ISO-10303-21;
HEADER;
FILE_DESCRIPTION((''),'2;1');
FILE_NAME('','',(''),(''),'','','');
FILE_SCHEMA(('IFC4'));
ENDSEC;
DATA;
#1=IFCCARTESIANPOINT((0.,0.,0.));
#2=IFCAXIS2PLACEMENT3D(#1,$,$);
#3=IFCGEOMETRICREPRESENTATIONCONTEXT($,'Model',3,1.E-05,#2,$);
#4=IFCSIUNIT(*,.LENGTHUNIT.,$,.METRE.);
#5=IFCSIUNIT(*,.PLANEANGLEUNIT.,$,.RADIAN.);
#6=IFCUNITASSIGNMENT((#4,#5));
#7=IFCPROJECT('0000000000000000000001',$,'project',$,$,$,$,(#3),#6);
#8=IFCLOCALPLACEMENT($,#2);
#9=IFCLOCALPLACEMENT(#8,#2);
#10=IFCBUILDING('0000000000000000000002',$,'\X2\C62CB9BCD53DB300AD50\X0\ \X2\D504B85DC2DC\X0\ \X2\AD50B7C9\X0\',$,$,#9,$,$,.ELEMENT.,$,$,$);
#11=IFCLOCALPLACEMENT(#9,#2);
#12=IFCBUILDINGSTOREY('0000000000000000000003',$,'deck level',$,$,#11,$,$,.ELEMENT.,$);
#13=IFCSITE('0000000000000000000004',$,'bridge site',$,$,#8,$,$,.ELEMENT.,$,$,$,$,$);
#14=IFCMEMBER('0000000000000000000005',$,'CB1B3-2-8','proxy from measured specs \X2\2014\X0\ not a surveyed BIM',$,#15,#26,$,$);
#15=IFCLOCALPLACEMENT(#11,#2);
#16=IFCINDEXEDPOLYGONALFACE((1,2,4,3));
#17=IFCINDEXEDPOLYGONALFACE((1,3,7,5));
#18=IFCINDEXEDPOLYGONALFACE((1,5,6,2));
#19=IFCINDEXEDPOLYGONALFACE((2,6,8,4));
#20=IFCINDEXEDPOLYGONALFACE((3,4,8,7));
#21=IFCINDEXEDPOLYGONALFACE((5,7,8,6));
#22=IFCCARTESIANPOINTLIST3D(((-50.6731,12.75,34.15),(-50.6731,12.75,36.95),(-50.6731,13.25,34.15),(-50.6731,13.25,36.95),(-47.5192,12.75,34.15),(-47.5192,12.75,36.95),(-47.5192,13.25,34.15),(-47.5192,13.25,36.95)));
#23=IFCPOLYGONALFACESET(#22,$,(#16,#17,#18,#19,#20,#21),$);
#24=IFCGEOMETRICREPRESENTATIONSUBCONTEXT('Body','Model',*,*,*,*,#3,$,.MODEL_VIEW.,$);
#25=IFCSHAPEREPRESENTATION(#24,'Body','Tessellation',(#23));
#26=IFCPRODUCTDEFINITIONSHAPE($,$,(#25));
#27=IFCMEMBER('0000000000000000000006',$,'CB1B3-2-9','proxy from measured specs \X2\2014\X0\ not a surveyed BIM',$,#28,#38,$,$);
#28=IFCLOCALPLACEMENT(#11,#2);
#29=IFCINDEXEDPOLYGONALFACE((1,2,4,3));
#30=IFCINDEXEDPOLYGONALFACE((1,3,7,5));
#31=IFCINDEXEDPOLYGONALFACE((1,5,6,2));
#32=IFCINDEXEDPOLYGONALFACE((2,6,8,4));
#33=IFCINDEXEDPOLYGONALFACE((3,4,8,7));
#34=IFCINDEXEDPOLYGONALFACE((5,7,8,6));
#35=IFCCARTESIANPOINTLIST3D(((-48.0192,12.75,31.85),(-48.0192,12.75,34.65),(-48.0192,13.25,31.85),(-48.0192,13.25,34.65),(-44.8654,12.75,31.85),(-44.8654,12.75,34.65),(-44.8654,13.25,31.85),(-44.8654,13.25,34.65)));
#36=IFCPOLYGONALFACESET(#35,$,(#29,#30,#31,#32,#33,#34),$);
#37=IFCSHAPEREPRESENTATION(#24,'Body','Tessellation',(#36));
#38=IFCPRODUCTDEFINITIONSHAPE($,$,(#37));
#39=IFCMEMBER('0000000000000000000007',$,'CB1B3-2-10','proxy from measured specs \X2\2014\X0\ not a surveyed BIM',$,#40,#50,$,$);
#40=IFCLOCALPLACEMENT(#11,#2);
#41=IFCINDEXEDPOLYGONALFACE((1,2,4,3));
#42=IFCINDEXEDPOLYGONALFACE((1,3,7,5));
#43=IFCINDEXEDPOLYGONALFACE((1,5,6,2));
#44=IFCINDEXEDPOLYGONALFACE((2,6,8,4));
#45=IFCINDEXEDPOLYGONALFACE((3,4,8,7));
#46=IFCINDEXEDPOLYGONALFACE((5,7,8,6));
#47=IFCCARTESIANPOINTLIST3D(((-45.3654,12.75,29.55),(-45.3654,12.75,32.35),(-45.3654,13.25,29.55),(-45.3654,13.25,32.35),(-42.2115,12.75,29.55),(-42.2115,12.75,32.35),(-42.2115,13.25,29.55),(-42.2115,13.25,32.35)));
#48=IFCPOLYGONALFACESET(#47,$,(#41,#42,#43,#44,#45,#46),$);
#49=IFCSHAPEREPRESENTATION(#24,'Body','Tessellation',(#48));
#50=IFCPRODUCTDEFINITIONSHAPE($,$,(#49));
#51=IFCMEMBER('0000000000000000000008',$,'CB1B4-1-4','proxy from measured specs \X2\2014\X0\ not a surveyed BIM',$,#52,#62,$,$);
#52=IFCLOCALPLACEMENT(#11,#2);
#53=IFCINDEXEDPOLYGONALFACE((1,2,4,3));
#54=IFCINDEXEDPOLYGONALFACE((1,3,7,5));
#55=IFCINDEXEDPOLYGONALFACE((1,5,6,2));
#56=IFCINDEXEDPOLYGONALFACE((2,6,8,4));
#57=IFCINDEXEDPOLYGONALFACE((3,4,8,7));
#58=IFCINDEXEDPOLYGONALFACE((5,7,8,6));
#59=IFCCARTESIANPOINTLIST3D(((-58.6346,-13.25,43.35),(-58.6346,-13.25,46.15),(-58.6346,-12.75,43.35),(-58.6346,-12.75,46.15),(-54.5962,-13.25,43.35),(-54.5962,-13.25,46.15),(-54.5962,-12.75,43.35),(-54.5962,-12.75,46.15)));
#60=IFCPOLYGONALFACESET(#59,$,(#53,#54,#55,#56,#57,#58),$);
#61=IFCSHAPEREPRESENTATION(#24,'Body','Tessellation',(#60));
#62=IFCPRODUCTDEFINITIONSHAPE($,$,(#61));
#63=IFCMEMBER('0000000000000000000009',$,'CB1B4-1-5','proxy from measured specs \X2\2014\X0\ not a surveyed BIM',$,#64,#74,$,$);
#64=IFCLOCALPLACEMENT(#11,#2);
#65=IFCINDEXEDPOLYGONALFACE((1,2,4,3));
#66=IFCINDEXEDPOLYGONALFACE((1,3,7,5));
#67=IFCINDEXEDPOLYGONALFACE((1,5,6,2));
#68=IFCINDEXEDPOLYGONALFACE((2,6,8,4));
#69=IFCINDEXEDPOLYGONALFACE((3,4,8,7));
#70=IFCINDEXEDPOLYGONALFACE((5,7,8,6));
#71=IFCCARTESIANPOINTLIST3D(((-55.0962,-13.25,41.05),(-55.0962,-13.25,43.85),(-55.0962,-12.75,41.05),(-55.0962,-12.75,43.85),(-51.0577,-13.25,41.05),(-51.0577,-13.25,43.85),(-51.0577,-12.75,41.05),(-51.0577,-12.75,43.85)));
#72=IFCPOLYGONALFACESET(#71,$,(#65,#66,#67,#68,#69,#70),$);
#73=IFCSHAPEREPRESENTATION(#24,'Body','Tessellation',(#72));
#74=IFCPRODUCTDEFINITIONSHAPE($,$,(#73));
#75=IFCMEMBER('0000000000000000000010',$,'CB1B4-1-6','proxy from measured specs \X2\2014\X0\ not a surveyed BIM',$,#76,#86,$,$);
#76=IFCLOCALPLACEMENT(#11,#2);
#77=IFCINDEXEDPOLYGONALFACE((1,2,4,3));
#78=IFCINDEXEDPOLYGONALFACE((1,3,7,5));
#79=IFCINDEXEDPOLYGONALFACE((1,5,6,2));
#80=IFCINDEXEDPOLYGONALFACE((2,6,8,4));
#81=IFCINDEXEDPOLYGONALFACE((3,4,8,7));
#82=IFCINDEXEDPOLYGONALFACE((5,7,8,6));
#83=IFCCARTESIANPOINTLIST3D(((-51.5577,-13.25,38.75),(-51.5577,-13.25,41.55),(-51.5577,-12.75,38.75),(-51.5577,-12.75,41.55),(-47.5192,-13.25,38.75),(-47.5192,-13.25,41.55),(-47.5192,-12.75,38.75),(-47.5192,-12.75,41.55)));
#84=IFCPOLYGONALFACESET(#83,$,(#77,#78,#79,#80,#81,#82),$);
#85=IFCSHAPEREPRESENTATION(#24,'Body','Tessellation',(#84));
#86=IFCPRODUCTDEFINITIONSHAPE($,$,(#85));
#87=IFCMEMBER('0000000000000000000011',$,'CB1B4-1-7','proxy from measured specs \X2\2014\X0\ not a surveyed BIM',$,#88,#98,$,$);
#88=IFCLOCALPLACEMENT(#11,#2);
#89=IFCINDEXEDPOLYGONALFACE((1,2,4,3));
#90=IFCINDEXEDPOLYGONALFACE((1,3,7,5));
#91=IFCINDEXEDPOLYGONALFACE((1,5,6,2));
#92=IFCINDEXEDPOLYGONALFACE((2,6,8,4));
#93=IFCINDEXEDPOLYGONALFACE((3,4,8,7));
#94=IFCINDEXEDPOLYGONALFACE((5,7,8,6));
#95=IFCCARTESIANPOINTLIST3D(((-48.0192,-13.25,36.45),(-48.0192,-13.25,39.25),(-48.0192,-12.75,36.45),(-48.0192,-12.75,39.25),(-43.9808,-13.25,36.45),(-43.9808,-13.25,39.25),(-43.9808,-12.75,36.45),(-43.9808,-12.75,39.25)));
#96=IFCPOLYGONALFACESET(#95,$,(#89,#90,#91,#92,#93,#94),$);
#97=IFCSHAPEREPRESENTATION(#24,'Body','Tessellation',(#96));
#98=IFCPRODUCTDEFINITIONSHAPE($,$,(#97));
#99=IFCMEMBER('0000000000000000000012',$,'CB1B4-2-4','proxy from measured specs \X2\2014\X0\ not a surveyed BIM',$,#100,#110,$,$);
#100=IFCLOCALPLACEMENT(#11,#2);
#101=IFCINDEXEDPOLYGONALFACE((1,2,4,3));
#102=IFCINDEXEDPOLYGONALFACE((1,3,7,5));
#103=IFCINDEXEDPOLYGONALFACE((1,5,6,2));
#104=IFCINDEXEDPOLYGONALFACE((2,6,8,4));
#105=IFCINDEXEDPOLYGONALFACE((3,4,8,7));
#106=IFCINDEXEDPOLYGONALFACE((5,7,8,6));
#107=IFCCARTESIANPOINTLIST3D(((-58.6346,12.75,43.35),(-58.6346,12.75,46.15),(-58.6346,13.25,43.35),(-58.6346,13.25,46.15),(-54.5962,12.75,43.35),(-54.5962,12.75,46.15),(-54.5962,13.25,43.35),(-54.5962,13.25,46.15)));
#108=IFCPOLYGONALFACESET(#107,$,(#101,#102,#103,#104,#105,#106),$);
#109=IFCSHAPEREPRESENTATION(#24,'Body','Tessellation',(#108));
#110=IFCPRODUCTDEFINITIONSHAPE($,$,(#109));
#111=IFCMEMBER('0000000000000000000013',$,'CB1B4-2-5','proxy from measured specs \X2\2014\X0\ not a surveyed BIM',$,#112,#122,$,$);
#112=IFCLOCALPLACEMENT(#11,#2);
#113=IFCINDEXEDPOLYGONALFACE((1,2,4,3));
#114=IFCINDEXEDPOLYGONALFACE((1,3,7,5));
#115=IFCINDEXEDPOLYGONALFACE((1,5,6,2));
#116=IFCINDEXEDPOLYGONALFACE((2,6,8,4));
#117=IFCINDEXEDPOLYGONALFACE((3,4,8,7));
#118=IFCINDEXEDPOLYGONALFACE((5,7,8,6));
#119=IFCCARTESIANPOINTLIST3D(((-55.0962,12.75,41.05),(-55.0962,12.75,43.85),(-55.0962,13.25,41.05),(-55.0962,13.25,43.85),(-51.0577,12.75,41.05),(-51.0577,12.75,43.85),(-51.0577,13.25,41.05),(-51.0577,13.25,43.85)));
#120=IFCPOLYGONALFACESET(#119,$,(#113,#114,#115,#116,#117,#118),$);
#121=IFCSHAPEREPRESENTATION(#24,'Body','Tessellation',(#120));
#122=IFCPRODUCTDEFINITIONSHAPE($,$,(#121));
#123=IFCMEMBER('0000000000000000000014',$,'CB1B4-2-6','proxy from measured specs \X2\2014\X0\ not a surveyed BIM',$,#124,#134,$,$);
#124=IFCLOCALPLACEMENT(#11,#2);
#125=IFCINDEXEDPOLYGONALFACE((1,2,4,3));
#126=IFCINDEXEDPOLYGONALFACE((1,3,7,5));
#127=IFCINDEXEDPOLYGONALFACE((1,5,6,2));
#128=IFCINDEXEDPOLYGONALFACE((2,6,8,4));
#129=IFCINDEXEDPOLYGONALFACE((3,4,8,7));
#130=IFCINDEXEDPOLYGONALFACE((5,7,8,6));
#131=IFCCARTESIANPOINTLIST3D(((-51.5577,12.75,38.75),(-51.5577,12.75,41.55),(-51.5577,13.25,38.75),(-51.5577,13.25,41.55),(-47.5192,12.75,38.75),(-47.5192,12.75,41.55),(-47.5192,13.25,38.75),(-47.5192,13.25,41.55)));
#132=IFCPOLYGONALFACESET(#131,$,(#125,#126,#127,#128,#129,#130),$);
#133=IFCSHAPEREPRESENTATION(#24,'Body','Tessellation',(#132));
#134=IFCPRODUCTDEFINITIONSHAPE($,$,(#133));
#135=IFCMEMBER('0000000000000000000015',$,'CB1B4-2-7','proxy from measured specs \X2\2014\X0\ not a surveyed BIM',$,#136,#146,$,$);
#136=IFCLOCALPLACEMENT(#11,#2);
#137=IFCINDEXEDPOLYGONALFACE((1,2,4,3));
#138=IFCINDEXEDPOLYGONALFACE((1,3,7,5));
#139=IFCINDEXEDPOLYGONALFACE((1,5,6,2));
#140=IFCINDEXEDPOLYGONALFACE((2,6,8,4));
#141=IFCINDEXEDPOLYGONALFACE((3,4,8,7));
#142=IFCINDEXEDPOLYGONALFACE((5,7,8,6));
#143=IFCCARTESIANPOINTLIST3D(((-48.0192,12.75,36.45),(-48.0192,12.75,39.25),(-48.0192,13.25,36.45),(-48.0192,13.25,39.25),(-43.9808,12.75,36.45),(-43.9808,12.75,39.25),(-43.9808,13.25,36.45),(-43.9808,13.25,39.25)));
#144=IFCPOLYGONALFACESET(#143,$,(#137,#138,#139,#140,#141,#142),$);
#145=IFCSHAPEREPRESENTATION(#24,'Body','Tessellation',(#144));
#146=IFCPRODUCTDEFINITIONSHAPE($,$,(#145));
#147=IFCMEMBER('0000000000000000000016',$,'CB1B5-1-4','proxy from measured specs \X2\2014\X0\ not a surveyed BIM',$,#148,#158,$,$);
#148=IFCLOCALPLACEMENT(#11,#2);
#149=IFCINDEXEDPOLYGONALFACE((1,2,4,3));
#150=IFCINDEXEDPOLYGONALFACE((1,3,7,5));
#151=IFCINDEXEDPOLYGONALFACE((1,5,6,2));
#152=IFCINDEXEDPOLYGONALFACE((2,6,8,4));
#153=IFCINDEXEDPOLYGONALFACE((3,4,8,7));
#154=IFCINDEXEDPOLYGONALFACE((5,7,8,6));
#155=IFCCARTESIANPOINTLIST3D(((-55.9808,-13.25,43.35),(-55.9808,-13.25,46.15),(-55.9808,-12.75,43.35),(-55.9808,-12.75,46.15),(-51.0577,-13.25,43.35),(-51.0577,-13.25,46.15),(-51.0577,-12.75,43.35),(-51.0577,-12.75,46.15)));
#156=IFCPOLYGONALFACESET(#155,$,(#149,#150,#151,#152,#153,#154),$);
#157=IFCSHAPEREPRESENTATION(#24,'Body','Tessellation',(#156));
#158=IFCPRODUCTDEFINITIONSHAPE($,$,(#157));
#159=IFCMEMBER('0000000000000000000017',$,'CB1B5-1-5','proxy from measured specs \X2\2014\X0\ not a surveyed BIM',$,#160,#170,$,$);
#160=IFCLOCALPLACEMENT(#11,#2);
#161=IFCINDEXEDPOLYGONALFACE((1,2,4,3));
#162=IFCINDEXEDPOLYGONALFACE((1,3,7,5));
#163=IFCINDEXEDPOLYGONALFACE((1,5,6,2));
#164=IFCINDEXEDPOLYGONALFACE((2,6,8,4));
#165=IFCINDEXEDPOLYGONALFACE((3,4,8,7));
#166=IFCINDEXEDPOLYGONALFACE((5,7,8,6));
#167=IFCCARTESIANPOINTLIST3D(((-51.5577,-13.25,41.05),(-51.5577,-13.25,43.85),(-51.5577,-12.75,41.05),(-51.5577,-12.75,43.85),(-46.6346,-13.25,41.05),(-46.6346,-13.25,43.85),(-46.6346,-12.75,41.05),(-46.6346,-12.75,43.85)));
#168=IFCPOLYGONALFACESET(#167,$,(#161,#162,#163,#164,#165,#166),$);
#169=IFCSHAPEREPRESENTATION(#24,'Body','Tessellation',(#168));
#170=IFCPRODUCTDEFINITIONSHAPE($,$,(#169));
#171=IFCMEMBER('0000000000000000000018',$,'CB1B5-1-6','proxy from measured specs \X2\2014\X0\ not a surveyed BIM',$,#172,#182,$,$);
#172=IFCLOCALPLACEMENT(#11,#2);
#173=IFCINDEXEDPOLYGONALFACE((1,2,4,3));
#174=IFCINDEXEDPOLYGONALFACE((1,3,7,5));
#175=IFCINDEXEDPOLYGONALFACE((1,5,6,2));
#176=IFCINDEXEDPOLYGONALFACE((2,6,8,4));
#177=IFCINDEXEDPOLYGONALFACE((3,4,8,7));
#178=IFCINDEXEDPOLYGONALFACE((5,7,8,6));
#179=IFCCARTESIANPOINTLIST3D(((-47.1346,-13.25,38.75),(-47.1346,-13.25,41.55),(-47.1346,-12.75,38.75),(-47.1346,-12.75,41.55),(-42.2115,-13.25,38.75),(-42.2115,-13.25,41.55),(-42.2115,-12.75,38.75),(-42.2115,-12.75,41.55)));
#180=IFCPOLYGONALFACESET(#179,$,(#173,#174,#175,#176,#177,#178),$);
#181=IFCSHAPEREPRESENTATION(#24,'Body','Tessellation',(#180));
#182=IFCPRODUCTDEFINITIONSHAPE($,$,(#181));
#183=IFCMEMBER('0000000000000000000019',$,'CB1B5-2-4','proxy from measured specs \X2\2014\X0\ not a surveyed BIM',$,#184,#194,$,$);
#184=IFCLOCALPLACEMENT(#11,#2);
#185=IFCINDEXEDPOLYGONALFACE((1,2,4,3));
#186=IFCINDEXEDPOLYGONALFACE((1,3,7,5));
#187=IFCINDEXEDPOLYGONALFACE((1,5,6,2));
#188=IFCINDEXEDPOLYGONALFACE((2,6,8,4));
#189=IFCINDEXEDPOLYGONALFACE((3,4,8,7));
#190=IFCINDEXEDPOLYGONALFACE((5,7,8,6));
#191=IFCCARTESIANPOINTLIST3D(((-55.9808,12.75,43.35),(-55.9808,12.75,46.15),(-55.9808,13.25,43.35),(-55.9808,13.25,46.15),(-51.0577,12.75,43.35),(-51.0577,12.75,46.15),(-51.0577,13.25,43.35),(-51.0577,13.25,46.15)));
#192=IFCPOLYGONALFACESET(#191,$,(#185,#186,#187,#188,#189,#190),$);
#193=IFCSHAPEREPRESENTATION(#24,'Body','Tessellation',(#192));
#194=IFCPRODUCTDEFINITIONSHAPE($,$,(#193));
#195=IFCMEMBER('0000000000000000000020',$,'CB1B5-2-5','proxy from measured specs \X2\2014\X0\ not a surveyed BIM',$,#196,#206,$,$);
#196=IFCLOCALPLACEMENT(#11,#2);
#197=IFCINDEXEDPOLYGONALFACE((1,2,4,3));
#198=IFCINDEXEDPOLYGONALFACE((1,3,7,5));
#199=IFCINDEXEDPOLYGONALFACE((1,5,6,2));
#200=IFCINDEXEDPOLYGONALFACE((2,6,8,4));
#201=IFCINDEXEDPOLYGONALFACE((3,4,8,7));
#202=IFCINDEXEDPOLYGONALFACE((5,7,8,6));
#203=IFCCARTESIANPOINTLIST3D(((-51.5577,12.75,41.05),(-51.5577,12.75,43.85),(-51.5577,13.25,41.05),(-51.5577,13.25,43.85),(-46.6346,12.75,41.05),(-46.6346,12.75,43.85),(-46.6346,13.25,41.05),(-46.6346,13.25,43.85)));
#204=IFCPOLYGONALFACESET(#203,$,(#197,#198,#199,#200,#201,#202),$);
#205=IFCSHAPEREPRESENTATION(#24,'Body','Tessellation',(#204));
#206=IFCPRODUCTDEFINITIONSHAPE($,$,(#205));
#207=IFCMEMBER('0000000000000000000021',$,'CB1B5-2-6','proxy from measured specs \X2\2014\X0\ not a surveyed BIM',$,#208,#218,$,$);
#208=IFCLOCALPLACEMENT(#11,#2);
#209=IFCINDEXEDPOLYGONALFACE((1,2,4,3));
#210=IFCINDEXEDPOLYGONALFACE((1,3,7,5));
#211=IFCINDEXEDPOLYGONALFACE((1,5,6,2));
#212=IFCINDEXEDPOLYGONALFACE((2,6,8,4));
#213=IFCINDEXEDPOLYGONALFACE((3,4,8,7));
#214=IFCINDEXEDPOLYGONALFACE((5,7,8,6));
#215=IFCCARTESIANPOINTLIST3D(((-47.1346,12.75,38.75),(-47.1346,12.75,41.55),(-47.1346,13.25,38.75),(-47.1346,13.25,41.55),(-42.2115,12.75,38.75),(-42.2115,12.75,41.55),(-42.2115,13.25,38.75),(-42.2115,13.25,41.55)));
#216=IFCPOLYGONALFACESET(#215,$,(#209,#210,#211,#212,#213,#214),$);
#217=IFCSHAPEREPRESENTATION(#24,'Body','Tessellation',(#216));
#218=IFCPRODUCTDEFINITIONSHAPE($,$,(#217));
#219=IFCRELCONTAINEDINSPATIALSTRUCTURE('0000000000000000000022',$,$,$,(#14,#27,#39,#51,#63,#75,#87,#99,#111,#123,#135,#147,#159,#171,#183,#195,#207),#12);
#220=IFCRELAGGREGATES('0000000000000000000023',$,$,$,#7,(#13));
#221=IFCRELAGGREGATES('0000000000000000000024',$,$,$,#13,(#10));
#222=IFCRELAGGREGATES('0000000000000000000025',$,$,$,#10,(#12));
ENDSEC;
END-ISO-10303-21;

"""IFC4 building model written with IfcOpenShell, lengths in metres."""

from ifc_helpers import new_model, si_unit, frame, origin, origin_2d, place, context, subcontext, project, spatial, rectangle, extrude, element, save


model = new_model("IFC4")

# Units and contexts
model_context = context("Model", 3, precision=1e-05, world=origin())
body_context = subcontext(model_context, "Body", "Model", "MODEL_VIEW")
ifc_project = project(units=[si_unit("LENGTHUNIT", "METRE"), si_unit("PLANEANGLEUNIT", "RADIAN")], contexts=[model_context])

# Site, building, storey
site_placement = place(None, origin())
site = spatial("IfcSite", under=ifc_project, at=site_placement, Name="bridge site", CompositionType="ELEMENT")
building_placement = place(site_placement, origin())
building = spatial("IfcBuilding", under=site, at=building_placement, Name="올림픽대교 프록시 교량", CompositionType="ELEMENT")
storey_placement = place(building_placement, origin())
storey = spatial("IfcBuildingStorey", under=building, at=storey_placement, Name="deck level", CompositionType="ELEMENT")

# Members
member_1_placement = place(storey_placement, frame((-49.0962, 13.0, 34.15)))
element("IfcMember", 1, at=member_1_placement, inside=storey, Name="CB1B3-2-8", Description="proxy from measured specs — not a surveyed BIM", context=body_context, shape_type="SweptSolid", body=[
    extrude(rectangle(XDim=3.1538, YDim=0.5, at=origin_2d()), origin(), (0.0, 0.0, 1.0), 2.8),
])
member_2_placement = place(storey_placement, frame((-46.4423, 13.0, 31.85)))
element("IfcMember", 2, at=member_2_placement, inside=storey, Name="CB1B3-2-9", Description="proxy from measured specs — not a surveyed BIM", context=body_context, shape_type="SweptSolid", body=[
    extrude(rectangle(XDim=3.1538, YDim=0.5, at=origin_2d()), origin(), (0.0, 0.0, 1.0), 2.8),
])
member_3_placement = place(storey_placement, frame((-43.7885, 13.0, 29.55)))
element("IfcMember", 3, at=member_3_placement, inside=storey, Name="CB1B3-2-10", Description="proxy from measured specs — not a surveyed BIM", context=body_context, shape_type="SweptSolid", body=[
    extrude(rectangle(XDim=3.1538, YDim=0.5, at=origin_2d()), origin(), (0.0, 0.0, 1.0), 2.8),
])
member_4_placement = place(storey_placement, frame((-56.6154, -13.0, 43.35)))
element("IfcMember", 4, at=member_4_placement, inside=storey, Name="CB1B4-1-4", Description="proxy from measured specs — not a surveyed BIM", context=body_context, shape_type="SweptSolid", body=[
    extrude(rectangle(XDim=4.0385, YDim=0.5, at=origin_2d()), origin(), (0.0, 0.0, 1.0), 2.8),
])
member_5_placement = place(storey_placement, frame((-53.0769, -13.0, 41.05)))
element("IfcMember", 5, at=member_5_placement, inside=storey, Name="CB1B4-1-5", Description="proxy from measured specs — not a surveyed BIM", context=body_context, shape_type="SweptSolid", body=[
    extrude(rectangle(XDim=4.0385, YDim=0.5, at=origin_2d()), origin(), (0.0, 0.0, 1.0), 2.8),
])
member_6_placement = place(storey_placement, frame((-49.5385, -13.0, 38.75)))
element("IfcMember", 6, at=member_6_placement, inside=storey, Name="CB1B4-1-6", Description="proxy from measured specs — not a surveyed BIM", context=body_context, shape_type="SweptSolid", body=[
    extrude(rectangle(XDim=4.0385, YDim=0.5, at=origin_2d()), origin(), (0.0, 0.0, 1.0), 2.8),
])
member_7_placement = place(storey_placement, frame((-46.0, -13.0, 36.45)))
element("IfcMember", 7, at=member_7_placement, inside=storey, Name="CB1B4-1-7", Description="proxy from measured specs — not a surveyed BIM", context=body_context, shape_type="SweptSolid", body=[
    extrude(rectangle(XDim=4.0385, YDim=0.5, at=origin_2d()), origin(), (0.0, 0.0, 1.0), 2.8),
])
member_8_placement = place(storey_placement, frame((-56.6154, 13.0, 43.35)))
element("IfcMember", 8, at=member_8_placement, inside=storey, Name="CB1B4-2-4", Description="proxy from measured specs — not a surveyed BIM", context=body_context, shape_type="SweptSolid", body=[
    extrude(rectangle(XDim=4.0385, YDim=0.5, at=origin_2d()), origin(), (0.0, 0.0, 1.0), 2.8),
])
member_9_placement = place(storey_placement, frame((-53.0769, 13.0, 41.05)))
element("IfcMember", 9, at=member_9_placement, inside=storey, Name="CB1B4-2-5", Description="proxy from measured specs — not a surveyed BIM", context=body_context, shape_type="SweptSolid", body=[
    extrude(rectangle(XDim=4.0385, YDim=0.5, at=origin_2d()), origin(), (0.0, 0.0, 1.0), 2.8),
])
member_10_placement = place(storey_placement, frame((-49.5385, 13.0, 38.75)))
element("IfcMember", 10, at=member_10_placement, inside=storey, Name="CB1B4-2-6", Description="proxy from measured specs — not a surveyed BIM", context=body_context, shape_type="SweptSolid", body=[
    extrude(rectangle(XDim=4.0385, YDim=0.5, at=origin_2d()), origin(), (0.0, 0.0, 1.0), 2.8),
])
member_11_placement = place(storey_placement, frame((-46.0, 13.0, 36.45)))
element("IfcMember", 11, at=member_11_placement, inside=storey, Name="CB1B4-2-7", Description="proxy from measured specs — not a surveyed BIM", context=body_context, shape_type="SweptSolid", body=[
    extrude(rectangle(XDim=4.0385, YDim=0.5, at=origin_2d()), origin(), (0.0, 0.0, 1.0), 2.8),
])
member_12_placement = place(storey_placement, frame((-53.5192, -13.0, 43.35)))
element("IfcMember", 12, at=member_12_placement, inside=storey, Name="CB1B5-1-4", Description="proxy from measured specs — not a surveyed BIM", context=body_context, shape_type="SweptSolid", body=[
    extrude(rectangle(XDim=4.9231, YDim=0.5, at=origin_2d()), origin(), (0.0, 0.0, 1.0), 2.8),
])
for number, where, name in (
    (13, (-49.0962, -13.0, 41.05), "CB1B5-1-5"),
    (14, (-44.6731, -13.0, 38.75), "CB1B5-1-6"),
):
    element("IfcMember", number, at=place(storey_placement, frame(where)), inside=storey, Name=name, Description="proxy from measured specs — not a surveyed BIM", context=body_context, shape_type="SweptSolid", body=[
        extrude(rectangle(XDim=4.9231, YDim=0.5, at=origin_2d()), origin(), (0.0, 0.0, 1.0), 2.8),
    ])
member_13_placement = place(storey_placement, frame((-53.5192, 13.0, 43.35)))
element("IfcMember", 15, at=member_13_placement, inside=storey, Name="CB1B5-2-4", Description="proxy from measured specs — not a surveyed BIM", context=body_context, shape_type="SweptSolid", body=[
    extrude(rectangle(XDim=4.9231, YDim=0.5, at=origin_2d()), origin(), (0.0, 0.0, 1.0), 2.8),
])
for number, where, name in (
    (16, (-49.0962, 13.0, 41.05), "CB1B5-2-5"),
    (17, (-44.6731, 13.0, 38.75), "CB1B5-2-6"),
):
    element("IfcMember", number, at=place(storey_placement, frame(where)), inside=storey, Name=name, Description="proxy from measured specs — not a surveyed BIM", context=body_context, shape_type="SweptSolid", body=[
        extrude(rectangle(XDim=4.9231, YDim=0.5, at=origin_2d()), origin(), (0.0, 0.0, 1.0), 2.8),
    ])

save(model, "model.ifc")
